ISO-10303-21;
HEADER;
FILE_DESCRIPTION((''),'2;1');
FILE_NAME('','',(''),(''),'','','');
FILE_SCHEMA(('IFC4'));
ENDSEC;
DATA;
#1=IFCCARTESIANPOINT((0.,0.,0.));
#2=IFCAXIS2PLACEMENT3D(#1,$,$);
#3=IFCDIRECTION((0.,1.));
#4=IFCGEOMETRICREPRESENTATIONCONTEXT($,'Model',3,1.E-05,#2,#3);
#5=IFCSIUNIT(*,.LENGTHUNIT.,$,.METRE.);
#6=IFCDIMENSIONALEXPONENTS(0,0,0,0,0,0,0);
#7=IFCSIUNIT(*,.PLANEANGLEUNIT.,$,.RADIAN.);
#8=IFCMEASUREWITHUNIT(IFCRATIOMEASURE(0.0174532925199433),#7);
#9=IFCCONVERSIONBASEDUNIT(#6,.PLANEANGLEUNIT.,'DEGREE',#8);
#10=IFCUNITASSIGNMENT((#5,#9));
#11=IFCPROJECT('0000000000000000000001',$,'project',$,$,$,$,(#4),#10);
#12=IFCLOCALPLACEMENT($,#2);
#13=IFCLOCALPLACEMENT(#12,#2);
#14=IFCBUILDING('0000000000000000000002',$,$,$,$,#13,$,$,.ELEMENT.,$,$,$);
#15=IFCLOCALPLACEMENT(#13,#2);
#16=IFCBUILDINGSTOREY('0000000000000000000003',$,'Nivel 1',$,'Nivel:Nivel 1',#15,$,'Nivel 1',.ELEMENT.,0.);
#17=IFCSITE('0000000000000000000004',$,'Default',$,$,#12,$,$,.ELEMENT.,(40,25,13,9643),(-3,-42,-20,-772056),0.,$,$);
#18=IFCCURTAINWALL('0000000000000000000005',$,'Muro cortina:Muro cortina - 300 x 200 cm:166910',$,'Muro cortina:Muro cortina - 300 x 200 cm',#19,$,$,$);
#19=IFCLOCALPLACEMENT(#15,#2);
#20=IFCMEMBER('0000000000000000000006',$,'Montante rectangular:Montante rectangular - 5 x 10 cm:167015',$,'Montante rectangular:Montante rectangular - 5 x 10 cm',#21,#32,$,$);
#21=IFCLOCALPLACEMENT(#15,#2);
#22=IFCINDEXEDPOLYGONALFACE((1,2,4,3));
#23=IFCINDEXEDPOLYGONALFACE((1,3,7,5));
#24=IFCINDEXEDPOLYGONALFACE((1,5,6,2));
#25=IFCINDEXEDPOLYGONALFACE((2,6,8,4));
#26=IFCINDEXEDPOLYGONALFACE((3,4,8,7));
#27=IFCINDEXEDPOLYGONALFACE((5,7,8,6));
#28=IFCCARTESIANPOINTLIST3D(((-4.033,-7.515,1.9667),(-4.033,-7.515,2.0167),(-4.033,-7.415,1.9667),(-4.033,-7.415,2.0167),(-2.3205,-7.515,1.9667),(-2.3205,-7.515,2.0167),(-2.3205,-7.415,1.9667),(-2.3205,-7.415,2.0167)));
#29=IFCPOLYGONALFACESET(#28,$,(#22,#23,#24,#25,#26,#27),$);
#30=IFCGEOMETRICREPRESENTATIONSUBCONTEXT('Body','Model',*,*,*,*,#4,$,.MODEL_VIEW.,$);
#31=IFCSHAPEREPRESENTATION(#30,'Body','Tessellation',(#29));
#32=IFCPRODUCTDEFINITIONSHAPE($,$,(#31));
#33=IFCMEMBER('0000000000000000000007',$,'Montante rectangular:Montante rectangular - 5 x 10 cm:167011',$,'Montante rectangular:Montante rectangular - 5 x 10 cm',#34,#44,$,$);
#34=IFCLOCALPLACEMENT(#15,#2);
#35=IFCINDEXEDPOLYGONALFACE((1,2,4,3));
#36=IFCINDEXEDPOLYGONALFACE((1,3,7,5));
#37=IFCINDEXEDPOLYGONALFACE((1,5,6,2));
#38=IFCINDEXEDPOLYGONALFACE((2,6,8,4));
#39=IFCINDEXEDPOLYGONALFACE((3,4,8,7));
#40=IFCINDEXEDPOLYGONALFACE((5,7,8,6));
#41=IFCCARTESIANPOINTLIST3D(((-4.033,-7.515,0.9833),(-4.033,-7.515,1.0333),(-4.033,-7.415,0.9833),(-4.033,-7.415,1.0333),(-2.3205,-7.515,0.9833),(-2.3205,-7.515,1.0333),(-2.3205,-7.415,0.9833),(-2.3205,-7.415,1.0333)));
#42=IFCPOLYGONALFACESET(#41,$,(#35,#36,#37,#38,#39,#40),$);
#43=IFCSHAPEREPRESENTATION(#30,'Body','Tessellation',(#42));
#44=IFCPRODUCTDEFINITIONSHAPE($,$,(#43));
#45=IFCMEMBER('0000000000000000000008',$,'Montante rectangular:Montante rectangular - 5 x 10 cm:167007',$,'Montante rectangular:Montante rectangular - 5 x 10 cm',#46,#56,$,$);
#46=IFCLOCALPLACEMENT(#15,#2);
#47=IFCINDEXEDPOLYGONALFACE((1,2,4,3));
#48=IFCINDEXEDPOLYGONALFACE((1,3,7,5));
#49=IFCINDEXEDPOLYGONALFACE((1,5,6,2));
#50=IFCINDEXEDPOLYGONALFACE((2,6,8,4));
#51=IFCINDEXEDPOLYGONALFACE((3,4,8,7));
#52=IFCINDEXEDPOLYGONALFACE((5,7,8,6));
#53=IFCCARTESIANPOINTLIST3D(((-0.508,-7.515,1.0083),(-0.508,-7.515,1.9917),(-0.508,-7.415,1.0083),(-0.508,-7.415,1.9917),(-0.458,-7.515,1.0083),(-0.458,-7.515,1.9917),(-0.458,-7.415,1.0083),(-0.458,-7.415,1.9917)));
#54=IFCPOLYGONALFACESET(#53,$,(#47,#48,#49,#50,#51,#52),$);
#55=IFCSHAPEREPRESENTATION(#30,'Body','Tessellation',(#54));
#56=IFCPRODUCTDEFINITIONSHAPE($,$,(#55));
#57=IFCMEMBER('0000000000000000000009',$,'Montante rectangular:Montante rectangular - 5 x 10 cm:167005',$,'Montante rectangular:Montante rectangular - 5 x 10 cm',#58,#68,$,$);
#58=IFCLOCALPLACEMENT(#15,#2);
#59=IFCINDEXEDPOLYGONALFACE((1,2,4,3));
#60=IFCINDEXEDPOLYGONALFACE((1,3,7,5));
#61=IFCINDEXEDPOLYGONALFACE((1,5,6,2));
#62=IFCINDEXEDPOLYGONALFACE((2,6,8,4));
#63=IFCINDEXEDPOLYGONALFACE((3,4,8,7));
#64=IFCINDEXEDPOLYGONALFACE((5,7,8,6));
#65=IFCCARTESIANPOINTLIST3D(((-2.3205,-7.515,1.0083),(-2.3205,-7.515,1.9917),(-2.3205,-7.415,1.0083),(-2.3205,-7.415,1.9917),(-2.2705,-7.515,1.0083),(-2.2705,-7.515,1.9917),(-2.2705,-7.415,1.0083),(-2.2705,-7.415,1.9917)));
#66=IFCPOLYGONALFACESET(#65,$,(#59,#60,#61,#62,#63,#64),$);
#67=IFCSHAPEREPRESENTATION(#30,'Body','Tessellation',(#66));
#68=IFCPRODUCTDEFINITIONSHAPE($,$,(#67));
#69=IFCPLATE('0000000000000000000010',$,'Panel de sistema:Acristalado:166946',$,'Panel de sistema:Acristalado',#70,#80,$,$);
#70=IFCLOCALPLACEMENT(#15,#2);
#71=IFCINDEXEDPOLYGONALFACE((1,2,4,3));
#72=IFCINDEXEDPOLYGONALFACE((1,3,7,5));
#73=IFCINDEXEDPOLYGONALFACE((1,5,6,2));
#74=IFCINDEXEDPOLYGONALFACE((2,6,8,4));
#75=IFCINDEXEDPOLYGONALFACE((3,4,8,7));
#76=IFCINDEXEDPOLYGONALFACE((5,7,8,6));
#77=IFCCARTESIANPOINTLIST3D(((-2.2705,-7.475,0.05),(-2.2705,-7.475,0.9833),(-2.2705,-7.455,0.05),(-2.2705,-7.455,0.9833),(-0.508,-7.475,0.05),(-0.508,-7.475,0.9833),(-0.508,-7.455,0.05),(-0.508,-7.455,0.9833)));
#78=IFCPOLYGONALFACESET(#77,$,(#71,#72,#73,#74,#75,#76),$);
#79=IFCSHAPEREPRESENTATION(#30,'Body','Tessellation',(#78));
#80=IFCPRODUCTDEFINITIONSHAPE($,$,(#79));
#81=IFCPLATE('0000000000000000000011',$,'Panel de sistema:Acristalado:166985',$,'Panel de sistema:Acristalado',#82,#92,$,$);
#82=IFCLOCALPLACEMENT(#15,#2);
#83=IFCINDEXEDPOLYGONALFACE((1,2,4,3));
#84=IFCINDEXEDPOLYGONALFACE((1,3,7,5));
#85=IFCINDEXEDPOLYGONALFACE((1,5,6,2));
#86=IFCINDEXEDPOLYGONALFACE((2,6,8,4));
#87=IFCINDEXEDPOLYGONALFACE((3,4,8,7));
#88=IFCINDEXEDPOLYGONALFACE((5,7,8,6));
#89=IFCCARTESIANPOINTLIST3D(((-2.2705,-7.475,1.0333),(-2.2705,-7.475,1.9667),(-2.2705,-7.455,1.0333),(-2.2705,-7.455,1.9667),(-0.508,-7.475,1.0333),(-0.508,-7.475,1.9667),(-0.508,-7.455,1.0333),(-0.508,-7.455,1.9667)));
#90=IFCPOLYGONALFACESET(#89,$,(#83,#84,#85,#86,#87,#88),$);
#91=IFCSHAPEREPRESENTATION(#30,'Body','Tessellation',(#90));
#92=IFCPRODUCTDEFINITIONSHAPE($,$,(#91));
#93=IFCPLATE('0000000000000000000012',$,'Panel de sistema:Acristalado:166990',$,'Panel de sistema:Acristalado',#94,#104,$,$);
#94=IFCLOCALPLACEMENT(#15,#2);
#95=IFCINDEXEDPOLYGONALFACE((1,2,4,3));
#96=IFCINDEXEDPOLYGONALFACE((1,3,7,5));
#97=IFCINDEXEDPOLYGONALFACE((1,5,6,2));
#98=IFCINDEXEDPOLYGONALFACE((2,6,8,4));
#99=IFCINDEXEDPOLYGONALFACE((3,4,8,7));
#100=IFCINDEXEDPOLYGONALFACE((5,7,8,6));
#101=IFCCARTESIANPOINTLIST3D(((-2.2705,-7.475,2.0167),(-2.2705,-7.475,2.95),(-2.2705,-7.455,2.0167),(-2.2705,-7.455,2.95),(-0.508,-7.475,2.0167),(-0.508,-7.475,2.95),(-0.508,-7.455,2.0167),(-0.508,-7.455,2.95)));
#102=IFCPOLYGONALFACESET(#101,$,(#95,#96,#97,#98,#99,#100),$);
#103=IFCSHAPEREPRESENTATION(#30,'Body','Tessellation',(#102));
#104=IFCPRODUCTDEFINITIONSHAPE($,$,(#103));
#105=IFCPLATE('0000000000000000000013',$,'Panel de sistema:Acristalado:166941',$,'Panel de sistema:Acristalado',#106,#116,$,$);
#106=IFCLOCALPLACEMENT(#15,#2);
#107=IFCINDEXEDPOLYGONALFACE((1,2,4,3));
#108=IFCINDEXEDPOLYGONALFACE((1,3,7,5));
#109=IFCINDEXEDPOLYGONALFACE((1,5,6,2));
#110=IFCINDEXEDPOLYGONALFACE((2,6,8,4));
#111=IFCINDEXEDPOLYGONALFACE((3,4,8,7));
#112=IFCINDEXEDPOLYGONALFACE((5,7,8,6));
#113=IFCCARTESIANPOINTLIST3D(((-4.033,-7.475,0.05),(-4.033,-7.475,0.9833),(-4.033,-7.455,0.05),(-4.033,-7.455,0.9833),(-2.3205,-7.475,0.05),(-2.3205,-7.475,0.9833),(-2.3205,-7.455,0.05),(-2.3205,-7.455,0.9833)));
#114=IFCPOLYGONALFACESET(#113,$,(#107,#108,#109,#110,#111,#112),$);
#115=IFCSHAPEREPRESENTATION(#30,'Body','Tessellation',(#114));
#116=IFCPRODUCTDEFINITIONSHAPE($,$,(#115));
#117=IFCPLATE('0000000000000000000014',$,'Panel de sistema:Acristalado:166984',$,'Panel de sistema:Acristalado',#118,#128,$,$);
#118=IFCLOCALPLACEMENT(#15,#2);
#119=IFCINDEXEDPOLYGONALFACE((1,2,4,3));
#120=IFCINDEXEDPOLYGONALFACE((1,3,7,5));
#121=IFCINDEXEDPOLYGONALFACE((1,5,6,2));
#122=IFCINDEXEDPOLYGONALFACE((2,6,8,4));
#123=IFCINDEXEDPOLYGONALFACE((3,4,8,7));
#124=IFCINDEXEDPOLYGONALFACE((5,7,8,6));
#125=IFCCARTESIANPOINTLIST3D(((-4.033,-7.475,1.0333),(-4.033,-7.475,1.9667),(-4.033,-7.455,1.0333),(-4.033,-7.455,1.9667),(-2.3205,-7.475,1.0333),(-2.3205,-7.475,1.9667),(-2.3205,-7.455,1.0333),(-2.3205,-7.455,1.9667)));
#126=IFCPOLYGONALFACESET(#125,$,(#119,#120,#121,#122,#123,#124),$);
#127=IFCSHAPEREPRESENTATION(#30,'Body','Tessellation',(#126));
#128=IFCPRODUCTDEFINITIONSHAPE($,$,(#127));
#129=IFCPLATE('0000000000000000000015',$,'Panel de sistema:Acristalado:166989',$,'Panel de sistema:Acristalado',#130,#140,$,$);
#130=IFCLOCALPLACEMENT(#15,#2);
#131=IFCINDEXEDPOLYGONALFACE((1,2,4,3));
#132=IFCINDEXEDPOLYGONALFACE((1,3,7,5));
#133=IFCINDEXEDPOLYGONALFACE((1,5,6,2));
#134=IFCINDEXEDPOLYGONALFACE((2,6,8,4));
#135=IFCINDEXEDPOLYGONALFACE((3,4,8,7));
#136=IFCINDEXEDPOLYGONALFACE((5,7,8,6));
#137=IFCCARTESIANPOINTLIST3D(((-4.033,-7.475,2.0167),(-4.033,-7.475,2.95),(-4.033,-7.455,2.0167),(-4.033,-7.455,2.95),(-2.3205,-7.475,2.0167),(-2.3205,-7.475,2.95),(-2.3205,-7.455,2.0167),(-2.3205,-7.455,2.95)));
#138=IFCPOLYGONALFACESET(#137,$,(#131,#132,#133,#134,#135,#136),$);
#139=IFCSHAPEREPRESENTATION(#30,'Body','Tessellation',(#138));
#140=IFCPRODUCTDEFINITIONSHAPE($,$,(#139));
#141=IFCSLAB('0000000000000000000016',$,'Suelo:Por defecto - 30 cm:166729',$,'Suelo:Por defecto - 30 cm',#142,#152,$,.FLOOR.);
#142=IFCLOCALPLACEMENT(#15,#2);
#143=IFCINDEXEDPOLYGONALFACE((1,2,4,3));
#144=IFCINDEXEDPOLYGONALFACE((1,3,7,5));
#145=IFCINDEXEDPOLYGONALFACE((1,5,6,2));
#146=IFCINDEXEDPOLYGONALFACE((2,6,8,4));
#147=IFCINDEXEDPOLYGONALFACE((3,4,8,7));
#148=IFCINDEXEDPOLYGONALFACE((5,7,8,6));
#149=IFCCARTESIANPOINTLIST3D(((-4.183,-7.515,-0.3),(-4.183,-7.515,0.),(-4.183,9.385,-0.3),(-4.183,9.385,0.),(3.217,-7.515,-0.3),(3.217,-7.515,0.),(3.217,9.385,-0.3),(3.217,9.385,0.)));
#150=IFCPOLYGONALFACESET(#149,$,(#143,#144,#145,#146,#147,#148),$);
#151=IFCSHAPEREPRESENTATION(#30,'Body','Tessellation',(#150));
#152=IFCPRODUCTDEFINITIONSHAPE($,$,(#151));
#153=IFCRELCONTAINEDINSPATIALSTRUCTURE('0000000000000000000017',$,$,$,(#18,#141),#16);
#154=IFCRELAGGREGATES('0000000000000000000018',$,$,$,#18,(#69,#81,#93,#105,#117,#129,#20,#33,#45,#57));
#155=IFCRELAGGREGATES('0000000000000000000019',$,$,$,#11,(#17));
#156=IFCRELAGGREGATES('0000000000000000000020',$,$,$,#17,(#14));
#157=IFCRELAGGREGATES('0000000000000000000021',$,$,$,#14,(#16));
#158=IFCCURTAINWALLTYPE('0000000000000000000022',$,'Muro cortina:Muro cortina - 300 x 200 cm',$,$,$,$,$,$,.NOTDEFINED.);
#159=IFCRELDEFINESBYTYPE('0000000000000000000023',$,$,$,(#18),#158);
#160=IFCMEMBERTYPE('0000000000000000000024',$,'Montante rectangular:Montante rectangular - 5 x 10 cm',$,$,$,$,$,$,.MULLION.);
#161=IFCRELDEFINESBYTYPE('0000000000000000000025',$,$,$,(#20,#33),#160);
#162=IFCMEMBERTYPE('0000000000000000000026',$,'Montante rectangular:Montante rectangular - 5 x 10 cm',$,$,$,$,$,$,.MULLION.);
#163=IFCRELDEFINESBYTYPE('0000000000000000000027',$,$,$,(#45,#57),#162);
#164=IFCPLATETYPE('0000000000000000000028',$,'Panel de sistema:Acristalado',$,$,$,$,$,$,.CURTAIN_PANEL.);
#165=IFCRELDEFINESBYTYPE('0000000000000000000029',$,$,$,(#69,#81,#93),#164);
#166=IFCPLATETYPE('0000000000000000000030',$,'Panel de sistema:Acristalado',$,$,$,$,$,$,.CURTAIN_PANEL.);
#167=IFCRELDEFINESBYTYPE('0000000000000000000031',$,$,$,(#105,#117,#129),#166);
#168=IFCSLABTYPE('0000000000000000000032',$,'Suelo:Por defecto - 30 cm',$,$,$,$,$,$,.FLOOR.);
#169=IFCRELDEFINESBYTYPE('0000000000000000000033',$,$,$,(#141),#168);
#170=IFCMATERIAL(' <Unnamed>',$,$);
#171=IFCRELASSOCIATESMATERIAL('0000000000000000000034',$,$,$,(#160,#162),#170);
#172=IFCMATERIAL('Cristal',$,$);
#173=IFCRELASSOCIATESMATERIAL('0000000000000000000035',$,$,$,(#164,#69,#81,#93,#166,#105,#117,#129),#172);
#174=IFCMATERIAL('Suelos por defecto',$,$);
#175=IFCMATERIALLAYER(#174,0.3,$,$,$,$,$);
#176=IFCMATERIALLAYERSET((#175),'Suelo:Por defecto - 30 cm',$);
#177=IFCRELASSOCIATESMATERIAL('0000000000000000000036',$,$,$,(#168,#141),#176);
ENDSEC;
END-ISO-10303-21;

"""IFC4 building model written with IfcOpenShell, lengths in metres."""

from ifc_helpers import new_model, entity, si_unit, converted_unit, direction, frame, origin, origin_2d_with_axis, place, context, subcontext, project, spatial, rectangle, extrude, source, transform, mapped, material, layer, layer_set, layer_usage, type_object, type_shapes, element, aggregate, save


model = new_model("IFC4")

# Units and contexts
model_context = context("Model", 3, precision=1e-05, world=origin(), true_north=direction((0.0, 1.0)))
body_context = subcontext(model_context, "Body", "Model", "MODEL_VIEW")
ifc_project = project(units=[si_unit("LENGTHUNIT", "METRE"), converted_unit("PLANEANGLEUNIT", "DEGREE", entity("IfcRatioMeasure", 0.0174532925199433), si_unit("PLANEANGLEUNIT", "RADIAN"), dimensions=[0, 0, 0, 0, 0, 0, 0])], contexts=[model_context])

# Site, building, storey
site_placement = place(None, origin())
site = spatial("IfcSite", under=ifc_project, at=site_placement, Name="Default", CompositionType="ELEMENT", RefLatitude=(40, 25, 13, 9643), RefLongitude=(-3, -42, -20, -772056), RefElevation=0.0)
building_placement = place(site_placement, origin())
building = spatial("IfcBuilding", under=site, at=building_placement, CompositionType="ELEMENT")
storey_placement = place(building_placement, origin())
storey = spatial("IfcBuildingStorey", under=building, at=storey_placement, Name="Nivel 1", ObjectType="Nivel:Nivel 1", LongName="Nivel 1", CompositionType="ELEMENT", Elevation=0.0)

# Curtain wall, members, plates
curtain_wall_type = type_object("IfcCurtainWallType", Name="Muro cortina:Muro cortina - 300 x 200 cm", PredefinedType="NOTDEFINED")
curtain_wall_placement = place(storey_placement, origin())
curtain_wall = element("IfcCurtainWall", 1, at=curtain_wall_placement, inside=storey, type_object=curtain_wall_type, Name="Muro cortina:Muro cortina - 300 x 200 cm:166910", ObjectType="Muro cortina:Muro cortina - 300 x 200 cm")
ifc_material_1 = material(Name=" <Unnamed>")
member_type_1 = type_object("IfcMemberType", Name="Montante rectangular:Montante rectangular - 5 x 10 cm", PredefinedType="MULLION", material=ifc_material_1)
shared_shape_1 = source(origin(), body_context, "Body", "SweptSolid", [
    extrude(rectangle(XDim=0.1, YDim=0.05, at=origin_2d_with_axis()), frame((0.0, 0.0, -1.7125), z_axis=(0.0, 0.0, 1.0), x_axis=(0.0, -1.0, 0.0)), (0.0, 0.0, 1.0), 1.7125),
])
type_shapes(member_type_1, [shared_shape_1])
member_1_placement = place(storey_placement, frame((-2.3205, -7.465, 1.9917), z_axis=(1.0, 0.0, 0.0), x_axis=(0.0, 0.0, 1.0)))
member_1 = element("IfcMember", 2, at=member_1_placement, type_object=member_type_1, Name="Montante rectangular:Montante rectangular - 5 x 10 cm:167015", ObjectType="Montante rectangular:Montante rectangular - 5 x 10 cm", context=body_context, shape_type="MappedRepresentation", body=[
    mapped(shared_shape_1, transform((0.0, 0.0, 0.0), scale=1.0)),
])
member_2_placement = place(storey_placement, frame((-2.3205, -7.465, 1.0083), z_axis=(1.0, 0.0, 0.0), x_axis=(0.0, 0.0, 1.0)))
member_2 = element("IfcMember", 3, at=member_2_placement, type_object=member_type_1, Name="Montante rectangular:Montante rectangular - 5 x 10 cm:167011", ObjectType="Montante rectangular:Montante rectangular - 5 x 10 cm", context=body_context, shape_type="MappedRepresentation", body=[
    mapped(shared_shape_1, transform((0.0, 0.0, 0.0), scale=1.0)),
])
member_type_2 = type_object("IfcMemberType", Name="Montante rectangular:Montante rectangular - 5 x 10 cm", PredefinedType="MULLION", material=ifc_material_1)
shared_shape_2 = source(origin(), body_context, "Body", "SweptSolid", [
    extrude(rectangle(XDim=0.1, YDim=0.05, at=origin_2d_with_axis()), frame((0.0, 0.0, -0.9833), z_axis=(0.0, 0.0, 1.0), x_axis=(0.0, -1.0, 0.0)), (0.0, 0.0, 1.0), 0.9833),
])
type_shapes(member_type_2, [shared_shape_2])
member_3_placement = place(storey_placement, frame((-0.483, -7.465, 1.0083), z_axis=(0.0, 0.0, -1.0), x_axis=(1.0, 0.0, 0.0)))
member_3 = element("IfcMember", 4, at=member_3_placement, type_object=member_type_2, Name="Montante rectangular:Montante rectangular - 5 x 10 cm:167007", ObjectType="Montante rectangular:Montante rectangular - 5 x 10 cm", context=body_context, shape_type="MappedRepresentation", body=[
    mapped(shared_shape_2, transform((0.0, 0.0, 0.0), scale=1.0)),
])
member_4_placement = place(storey_placement, frame((-2.2955, -7.465, 1.0083), z_axis=(0.0, 0.0, -1.0), x_axis=(1.0, 0.0, 0.0)))
member_4 = element("IfcMember", 5, at=member_4_placement, type_object=member_type_2, Name="Montante rectangular:Montante rectangular - 5 x 10 cm:167005", ObjectType="Montante rectangular:Montante rectangular - 5 x 10 cm", context=body_context, shape_type="MappedRepresentation", body=[
    mapped(shared_shape_2, transform((0.0, 0.0, 0.0), scale=1.0)),
])
ifc_material_2 = material(Name="Cristal")
plate_type_1 = type_object("IfcPlateType", Name="Panel de sistema:Acristalado", PredefinedType="CURTAIN_PANEL", material=ifc_material_2)
shared_shape_3 = source(origin(), body_context, "Body", "SweptSolid", [
    extrude(rectangle(XDim=0.02, YDim=1.7625, at=origin_2d_with_axis()), frame((0.0, 0.0, 0.0), z_axis=(0.0, 0.0, 1.0), x_axis=(0.0, 1.0, 0.0)), (0.0, 0.0, 1.0), 0.9333),
])
type_shapes(plate_type_1, [shared_shape_3])
plate_1_placement = place(curtain_wall_placement, frame((-1.3893, -7.465, 0.05)))
plate_1 = element("IfcPlate", 6, at=plate_1_placement, type_object=plate_type_1, material=ifc_material_2, Name="Panel de sistema:Acristalado:166946", ObjectType="Panel de sistema:Acristalado", context=body_context, shape_type="MappedRepresentation", body=[
    mapped(shared_shape_3, transform((0.0, 0.0, 0.0), scale=1.0)),
])
plate_2_placement = place(curtain_wall_placement, frame((-1.3893, -7.465, 1.0333)))
plate_2 = element("IfcPlate", 7, at=plate_2_placement, type_object=plate_type_1, material=ifc_material_2, Name="Panel de sistema:Acristalado:166985", ObjectType="Panel de sistema:Acristalado", context=body_context, shape_type="MappedRepresentation", body=[
    mapped(shared_shape_3, transform((0.0, 0.0, 0.0), scale=1.0)),
])
plate_3_placement = place(curtain_wall_placement, frame((-1.3893, -7.465, 2.0167)))
plate_3 = element("IfcPlate", 8, at=plate_3_placement, type_object=plate_type_1, material=ifc_material_2, Name="Panel de sistema:Acristalado:166990", ObjectType="Panel de sistema:Acristalado", context=body_context, shape_type="MappedRepresentation", body=[
    mapped(shared_shape_3, transform((0.0, 0.0, 0.0), scale=1.0)),
])
plate_type_2 = type_object("IfcPlateType", Name="Panel de sistema:Acristalado", PredefinedType="CURTAIN_PANEL", material=ifc_material_2)
shared_shape_4 = source(origin(), body_context, "Body", "SweptSolid", [
    extrude(rectangle(XDim=0.02, YDim=1.7125, at=origin_2d_with_axis()), frame((0.0, 0.0, 0.0), z_axis=(0.0, 0.0, 1.0), x_axis=(0.0, 1.0, 0.0)), (0.0, 0.0, 1.0), 0.9333),
])
type_shapes(plate_type_2, [shared_shape_4])
plate_4_placement = place(curtain_wall_placement, frame((-3.1768, -7.465, 0.05)))
plate_4 = element("IfcPlate", 9, at=plate_4_placement, type_object=plate_type_2, material=ifc_material_2, Name="Panel de sistema:Acristalado:166941", ObjectType="Panel de sistema:Acristalado", context=body_context, shape_type="MappedRepresentation", body=[
    mapped(shared_shape_4, transform((0.0, 0.0, 0.0), scale=1.0)),
])
plate_5_placement = place(curtain_wall_placement, frame((-3.1768, -7.465, 1.0333)))
plate_5 = element("IfcPlate", 10, at=plate_5_placement, type_object=plate_type_2, material=ifc_material_2, Name="Panel de sistema:Acristalado:166984", ObjectType="Panel de sistema:Acristalado", context=body_context, shape_type="MappedRepresentation", body=[
    mapped(shared_shape_4, transform((0.0, 0.0, 0.0), scale=1.0)),
])
plate_6_placement = place(curtain_wall_placement, frame((-3.1768, -7.465, 2.0167)))
plate_6 = element("IfcPlate", 11, at=plate_6_placement, type_object=plate_type_2, material=ifc_material_2, Name="Panel de sistema:Acristalado:166989", ObjectType="Panel de sistema:Acristalado", context=body_context, shape_type="MappedRepresentation", body=[
    mapped(shared_shape_4, transform((0.0, 0.0, 0.0), scale=1.0)),
])
aggregate(curtain_wall, [plate_1, plate_2, plate_3, plate_4, plate_5, plate_6, member_1, member_2, member_3, member_4])

# Slab
ifc_material_3 = material(Name="Suelos por defecto")
ifc_layer_1 = layer(ifc_material_3, 0.3)
ifc_layer_set_1 = layer_set([ifc_layer_1], Name="Suelo:Por defecto - 30 cm")
ifc_layer_usage_1 = layer_usage(ifc_layer_set_1, "AXIS3", "POSITIVE", 0.0)
slab_type = type_object("IfcSlabType", Name="Suelo:Por defecto - 30 cm", PredefinedType="FLOOR", material=ifc_layer_set_1)
slab_placement = place(storey_placement, origin())
element("IfcSlab", 12, at=slab_placement, inside=storey, type_object=slab_type, material=ifc_layer_usage_1, Name="Suelo:Por defecto - 30 cm:166729", ObjectType="Suelo:Por defecto - 30 cm", PredefinedType="FLOOR", context=body_context, shape_type="SweptSolid", body=[
    extrude(rectangle(XDim=16.9, YDim=7.4, at=origin_2d_with_axis()), frame((-0.483, 0.935, 0.0), z_axis=(0.0, 0.0, -1.0), x_axis=(0.0, 1.0, 0.0)), (0.0, 0.0, 1.0), 0.3),
])

save(model, "model.ifc")
